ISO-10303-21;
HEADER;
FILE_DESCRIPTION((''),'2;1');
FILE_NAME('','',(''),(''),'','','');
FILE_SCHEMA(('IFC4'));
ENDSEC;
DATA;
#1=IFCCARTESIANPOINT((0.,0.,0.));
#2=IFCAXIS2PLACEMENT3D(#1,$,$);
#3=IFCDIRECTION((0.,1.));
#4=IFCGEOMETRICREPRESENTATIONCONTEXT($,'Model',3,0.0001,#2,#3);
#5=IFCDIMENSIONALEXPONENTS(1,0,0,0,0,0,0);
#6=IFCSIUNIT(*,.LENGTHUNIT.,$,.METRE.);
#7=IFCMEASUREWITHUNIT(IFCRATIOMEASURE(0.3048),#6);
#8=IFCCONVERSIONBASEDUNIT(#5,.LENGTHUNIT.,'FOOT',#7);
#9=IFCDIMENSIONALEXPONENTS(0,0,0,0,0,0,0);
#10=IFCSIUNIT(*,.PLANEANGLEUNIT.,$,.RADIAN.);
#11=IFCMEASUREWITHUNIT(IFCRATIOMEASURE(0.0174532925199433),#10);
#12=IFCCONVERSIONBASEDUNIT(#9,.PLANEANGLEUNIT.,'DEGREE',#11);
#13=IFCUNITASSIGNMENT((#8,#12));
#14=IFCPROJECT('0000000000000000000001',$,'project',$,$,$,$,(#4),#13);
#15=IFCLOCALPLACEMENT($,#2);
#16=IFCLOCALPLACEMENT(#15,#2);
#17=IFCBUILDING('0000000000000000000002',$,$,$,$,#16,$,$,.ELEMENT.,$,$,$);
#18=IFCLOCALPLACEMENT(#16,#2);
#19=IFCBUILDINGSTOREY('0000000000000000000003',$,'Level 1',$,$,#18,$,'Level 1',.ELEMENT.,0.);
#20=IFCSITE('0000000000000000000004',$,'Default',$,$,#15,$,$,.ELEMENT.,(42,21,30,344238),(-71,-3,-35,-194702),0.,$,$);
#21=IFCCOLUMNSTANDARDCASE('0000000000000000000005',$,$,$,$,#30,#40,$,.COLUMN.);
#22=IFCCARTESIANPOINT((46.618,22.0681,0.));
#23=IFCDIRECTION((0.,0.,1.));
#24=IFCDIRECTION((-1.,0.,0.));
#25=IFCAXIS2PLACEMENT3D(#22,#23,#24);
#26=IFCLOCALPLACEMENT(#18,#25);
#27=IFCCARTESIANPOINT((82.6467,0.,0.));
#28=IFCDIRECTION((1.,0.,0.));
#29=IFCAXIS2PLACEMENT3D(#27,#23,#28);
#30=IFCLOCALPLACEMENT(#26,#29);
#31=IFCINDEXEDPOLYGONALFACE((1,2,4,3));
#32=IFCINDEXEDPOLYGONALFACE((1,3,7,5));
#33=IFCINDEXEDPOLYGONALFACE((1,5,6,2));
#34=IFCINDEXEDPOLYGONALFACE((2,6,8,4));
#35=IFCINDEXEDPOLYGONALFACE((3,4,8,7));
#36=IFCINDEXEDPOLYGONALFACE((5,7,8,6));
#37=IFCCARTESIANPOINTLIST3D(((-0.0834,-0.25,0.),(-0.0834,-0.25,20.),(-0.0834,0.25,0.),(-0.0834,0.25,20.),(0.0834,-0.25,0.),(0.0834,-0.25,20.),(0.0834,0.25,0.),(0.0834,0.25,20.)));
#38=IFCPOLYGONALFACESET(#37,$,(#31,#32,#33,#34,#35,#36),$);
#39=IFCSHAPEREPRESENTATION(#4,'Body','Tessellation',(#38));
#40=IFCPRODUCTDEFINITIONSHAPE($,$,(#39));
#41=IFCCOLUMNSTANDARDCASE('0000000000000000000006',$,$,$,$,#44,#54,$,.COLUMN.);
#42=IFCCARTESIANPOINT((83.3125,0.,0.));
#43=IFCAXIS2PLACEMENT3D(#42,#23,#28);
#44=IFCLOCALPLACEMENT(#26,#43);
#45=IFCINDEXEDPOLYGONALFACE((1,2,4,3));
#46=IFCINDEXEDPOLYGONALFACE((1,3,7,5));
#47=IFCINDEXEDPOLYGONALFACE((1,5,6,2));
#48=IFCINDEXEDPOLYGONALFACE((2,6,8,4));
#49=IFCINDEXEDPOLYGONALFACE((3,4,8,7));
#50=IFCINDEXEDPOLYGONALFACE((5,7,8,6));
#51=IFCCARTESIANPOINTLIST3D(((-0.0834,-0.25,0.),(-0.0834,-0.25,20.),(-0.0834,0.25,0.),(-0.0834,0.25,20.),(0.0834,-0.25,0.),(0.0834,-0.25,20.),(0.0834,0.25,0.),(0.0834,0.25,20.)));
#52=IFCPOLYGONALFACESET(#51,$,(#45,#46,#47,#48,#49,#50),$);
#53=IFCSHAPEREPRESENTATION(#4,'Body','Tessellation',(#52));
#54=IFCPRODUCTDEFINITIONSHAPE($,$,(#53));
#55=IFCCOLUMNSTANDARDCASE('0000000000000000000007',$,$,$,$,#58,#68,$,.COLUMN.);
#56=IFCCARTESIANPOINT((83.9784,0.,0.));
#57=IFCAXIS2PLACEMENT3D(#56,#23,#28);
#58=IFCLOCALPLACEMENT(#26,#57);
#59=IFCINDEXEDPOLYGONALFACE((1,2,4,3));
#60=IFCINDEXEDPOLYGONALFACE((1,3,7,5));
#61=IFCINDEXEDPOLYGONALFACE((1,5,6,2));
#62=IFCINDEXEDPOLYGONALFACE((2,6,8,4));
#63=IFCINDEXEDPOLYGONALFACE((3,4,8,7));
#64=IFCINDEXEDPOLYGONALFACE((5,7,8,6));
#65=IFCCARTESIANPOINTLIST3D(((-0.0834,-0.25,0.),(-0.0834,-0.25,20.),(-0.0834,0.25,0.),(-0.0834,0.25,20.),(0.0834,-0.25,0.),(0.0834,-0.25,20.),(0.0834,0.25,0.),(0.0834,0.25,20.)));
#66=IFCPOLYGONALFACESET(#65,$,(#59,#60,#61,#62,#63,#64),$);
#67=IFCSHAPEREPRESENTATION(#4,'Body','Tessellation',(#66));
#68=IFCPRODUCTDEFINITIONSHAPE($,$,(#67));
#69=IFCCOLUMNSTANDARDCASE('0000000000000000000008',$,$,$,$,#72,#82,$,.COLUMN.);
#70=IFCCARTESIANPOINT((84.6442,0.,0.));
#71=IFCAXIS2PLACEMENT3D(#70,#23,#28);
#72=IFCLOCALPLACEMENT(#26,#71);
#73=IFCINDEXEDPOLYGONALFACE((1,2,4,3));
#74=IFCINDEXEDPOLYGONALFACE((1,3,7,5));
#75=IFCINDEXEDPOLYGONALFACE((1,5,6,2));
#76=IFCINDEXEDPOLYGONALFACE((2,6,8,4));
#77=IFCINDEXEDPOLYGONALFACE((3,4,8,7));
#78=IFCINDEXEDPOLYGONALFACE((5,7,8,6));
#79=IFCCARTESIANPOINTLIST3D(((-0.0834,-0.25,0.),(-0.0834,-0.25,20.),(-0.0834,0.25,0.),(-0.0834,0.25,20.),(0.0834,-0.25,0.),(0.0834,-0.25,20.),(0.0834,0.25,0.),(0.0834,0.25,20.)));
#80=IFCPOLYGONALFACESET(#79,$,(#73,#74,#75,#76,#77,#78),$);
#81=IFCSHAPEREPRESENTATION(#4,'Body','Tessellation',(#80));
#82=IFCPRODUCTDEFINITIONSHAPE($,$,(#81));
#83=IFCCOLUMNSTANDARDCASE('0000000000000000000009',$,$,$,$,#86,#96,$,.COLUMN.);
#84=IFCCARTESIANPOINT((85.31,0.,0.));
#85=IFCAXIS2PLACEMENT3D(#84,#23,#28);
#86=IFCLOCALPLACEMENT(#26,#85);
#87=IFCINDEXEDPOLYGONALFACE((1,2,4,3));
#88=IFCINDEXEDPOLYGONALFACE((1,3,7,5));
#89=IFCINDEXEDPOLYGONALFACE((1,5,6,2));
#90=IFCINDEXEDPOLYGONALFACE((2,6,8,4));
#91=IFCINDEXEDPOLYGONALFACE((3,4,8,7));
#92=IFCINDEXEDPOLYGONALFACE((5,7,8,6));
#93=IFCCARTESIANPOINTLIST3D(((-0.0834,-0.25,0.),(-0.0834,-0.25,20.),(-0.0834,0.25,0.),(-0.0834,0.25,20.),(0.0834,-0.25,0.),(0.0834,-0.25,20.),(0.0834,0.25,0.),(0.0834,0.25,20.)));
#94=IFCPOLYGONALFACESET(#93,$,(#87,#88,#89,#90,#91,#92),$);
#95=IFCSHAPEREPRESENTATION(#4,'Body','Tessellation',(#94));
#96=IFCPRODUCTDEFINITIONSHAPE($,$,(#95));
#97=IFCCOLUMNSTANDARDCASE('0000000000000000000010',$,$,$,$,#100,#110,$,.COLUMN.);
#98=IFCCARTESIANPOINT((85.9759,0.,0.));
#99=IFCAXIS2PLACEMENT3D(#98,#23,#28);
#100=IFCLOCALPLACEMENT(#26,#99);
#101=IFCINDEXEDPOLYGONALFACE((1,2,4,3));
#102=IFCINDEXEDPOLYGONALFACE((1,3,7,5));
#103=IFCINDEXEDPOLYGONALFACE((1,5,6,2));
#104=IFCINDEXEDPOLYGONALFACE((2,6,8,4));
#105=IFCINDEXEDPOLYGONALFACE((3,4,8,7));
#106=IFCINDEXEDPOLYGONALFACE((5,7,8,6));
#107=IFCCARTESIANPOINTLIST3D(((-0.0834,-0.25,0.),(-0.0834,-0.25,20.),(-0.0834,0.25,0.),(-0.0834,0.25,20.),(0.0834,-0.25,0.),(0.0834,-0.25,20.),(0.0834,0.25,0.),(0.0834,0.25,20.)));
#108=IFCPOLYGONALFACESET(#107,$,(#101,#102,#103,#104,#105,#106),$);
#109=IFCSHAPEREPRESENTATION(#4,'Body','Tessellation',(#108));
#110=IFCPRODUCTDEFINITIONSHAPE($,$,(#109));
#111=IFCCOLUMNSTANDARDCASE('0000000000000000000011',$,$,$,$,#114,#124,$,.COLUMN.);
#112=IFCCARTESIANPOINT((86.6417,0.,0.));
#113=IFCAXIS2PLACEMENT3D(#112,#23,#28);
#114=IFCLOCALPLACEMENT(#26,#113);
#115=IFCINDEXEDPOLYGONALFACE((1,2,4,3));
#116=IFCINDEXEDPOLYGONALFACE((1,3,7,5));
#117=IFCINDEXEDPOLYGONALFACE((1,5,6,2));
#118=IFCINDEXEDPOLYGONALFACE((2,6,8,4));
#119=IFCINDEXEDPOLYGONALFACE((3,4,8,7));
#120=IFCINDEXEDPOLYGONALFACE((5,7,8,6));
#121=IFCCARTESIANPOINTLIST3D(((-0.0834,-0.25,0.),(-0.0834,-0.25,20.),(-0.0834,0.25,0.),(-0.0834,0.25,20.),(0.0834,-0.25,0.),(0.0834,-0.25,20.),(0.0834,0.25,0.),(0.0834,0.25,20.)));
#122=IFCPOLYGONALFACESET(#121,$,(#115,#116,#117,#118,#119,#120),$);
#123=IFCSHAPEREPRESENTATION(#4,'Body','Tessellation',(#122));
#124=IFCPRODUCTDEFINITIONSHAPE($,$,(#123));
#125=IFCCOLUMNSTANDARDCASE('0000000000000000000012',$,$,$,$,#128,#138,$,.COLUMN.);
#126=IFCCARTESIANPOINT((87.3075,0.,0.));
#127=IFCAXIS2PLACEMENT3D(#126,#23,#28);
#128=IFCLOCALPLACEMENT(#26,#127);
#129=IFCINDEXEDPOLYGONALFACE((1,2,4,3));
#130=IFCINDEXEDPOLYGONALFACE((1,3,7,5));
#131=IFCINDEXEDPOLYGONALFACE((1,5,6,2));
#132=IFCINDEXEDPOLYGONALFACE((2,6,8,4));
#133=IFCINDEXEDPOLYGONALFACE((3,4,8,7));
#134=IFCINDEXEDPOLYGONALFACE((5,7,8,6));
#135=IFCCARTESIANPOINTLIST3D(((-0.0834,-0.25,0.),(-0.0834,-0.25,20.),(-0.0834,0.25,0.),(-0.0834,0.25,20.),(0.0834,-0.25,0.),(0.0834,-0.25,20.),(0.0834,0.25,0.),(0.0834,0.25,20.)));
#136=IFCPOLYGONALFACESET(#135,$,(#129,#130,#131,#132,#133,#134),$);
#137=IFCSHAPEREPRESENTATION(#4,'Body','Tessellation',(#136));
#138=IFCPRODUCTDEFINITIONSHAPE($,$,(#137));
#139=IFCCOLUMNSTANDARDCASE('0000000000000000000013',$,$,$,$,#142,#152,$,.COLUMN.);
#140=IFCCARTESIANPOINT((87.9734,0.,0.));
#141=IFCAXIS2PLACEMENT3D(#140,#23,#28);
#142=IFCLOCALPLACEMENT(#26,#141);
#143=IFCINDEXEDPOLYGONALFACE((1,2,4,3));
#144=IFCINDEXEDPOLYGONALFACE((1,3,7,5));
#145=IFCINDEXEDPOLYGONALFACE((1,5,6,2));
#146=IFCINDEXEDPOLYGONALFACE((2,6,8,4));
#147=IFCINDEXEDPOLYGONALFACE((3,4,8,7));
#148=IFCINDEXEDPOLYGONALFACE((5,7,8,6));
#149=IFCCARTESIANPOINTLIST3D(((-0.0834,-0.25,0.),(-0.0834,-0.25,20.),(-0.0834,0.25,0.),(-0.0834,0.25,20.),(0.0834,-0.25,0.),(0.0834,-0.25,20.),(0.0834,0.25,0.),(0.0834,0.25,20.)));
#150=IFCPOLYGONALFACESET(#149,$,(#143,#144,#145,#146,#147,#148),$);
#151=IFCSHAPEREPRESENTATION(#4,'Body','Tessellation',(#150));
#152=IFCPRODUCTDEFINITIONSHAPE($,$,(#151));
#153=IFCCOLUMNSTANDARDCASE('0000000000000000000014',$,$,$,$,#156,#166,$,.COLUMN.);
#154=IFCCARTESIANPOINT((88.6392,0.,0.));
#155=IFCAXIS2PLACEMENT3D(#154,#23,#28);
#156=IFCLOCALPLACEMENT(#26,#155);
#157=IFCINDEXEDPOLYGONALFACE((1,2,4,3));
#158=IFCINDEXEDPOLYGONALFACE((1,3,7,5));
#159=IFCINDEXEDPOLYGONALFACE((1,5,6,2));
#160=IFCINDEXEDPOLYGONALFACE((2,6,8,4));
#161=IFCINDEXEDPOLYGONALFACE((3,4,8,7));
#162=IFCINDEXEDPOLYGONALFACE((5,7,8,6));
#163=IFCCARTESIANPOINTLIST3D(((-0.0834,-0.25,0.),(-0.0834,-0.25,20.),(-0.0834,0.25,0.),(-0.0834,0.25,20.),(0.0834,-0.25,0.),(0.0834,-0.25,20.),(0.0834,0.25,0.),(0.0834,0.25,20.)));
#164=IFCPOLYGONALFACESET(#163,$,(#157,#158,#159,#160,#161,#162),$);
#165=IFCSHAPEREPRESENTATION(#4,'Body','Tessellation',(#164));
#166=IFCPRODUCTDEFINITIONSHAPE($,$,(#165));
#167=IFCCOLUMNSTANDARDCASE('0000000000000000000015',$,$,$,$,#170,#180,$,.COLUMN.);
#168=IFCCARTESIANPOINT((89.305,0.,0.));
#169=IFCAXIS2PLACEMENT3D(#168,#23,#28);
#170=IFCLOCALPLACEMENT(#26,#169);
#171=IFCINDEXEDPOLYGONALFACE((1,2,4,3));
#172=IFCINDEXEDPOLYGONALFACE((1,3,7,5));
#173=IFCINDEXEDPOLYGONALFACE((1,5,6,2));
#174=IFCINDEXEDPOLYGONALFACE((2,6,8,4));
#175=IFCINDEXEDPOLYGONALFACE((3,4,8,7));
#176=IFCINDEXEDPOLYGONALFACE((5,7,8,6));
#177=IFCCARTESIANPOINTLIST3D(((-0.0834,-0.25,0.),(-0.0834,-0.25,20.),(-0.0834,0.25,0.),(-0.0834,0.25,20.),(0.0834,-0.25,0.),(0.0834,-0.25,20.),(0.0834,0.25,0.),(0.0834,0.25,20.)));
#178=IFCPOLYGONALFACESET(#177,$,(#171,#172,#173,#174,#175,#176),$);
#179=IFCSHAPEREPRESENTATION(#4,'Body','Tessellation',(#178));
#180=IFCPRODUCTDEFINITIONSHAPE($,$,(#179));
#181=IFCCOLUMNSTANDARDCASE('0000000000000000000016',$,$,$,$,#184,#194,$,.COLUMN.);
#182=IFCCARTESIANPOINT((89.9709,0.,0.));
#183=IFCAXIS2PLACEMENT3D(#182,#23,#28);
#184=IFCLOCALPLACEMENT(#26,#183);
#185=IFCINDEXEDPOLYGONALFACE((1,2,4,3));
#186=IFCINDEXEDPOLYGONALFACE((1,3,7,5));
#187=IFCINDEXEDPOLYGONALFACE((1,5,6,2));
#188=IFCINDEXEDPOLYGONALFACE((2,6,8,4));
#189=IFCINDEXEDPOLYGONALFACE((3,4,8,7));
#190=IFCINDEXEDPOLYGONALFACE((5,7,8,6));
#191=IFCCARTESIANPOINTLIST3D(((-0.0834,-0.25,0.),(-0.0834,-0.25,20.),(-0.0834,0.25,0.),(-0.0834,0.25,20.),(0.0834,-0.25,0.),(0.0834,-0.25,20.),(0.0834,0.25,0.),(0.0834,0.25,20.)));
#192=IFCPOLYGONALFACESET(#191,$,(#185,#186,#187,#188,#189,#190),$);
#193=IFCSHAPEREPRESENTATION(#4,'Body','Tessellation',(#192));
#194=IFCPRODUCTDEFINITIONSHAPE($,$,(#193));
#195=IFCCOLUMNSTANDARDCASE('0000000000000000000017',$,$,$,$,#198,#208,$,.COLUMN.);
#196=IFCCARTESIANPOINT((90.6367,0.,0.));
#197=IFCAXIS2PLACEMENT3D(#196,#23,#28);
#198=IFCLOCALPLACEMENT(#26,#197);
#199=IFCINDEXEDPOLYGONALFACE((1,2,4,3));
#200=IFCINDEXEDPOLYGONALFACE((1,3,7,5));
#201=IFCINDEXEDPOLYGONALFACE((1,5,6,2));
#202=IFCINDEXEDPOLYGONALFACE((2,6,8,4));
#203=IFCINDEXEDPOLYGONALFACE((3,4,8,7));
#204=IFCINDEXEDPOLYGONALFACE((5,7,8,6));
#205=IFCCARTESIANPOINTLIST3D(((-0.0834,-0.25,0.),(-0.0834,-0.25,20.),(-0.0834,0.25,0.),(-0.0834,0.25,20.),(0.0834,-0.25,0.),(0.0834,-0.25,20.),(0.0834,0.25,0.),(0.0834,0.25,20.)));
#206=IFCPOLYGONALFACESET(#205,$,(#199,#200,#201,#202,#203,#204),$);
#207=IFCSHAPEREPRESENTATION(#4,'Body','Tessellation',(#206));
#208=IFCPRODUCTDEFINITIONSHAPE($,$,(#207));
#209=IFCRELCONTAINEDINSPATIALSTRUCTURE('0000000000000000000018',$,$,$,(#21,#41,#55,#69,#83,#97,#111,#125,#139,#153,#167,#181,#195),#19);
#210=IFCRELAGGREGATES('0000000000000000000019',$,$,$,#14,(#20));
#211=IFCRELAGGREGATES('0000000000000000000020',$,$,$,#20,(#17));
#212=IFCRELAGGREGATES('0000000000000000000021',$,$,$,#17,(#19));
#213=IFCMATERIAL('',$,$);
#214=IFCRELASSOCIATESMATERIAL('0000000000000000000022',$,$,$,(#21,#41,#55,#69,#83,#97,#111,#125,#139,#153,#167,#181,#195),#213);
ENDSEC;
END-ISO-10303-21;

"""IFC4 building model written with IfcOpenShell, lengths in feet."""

from ifc_helpers import new_model, entity, si_unit, converted_unit, direction, frame, origin, place, context, project, spatial, rectangle, extrude, material, element, save


model = new_model("IFC4")

# Units and contexts
model_context = context("Model", 3, precision=0.0001, world=origin(), true_north=direction((0.0, 1.0)))
ifc_project = project(units=[converted_unit("LENGTHUNIT", "FOOT", entity("IfcRatioMeasure", 0.3048), si_unit("LENGTHUNIT", "METRE"), dimensions=[1, 0, 0, 0, 0, 0, 0]), converted_unit("PLANEANGLEUNIT", "DEGREE", entity("IfcRatioMeasure", 0.0174532925199433), si_unit("PLANEANGLEUNIT", "RADIAN"), dimensions=[0, 0, 0, 0, 0, 0, 0])], contexts=[model_context])

# Site, building, storey
site_placement = place(None, origin())
site = spatial("IfcSite", under=ifc_project, at=site_placement, Name="Default", CompositionType="ELEMENT", RefLatitude=(42, 21, 30, 344238), RefLongitude=(-71, -3, -35, -194702), RefElevation=0.0)
building_placement = place(site_placement, origin())
building = spatial("IfcBuilding", under=site, at=building_placement, CompositionType="ELEMENT")
storey_placement = place(building_placement, origin())
storey = spatial("IfcBuildingStorey", under=building, at=storey_placement, Name="Level 1", LongName="Level 1", CompositionType="ELEMENT", Elevation=0.0)

# Columns
ifc_material = material(Name="")
placement = place(storey_placement, frame((46.618, 22.0681, 0.0), z_axis=(0.0, 0.0, 1.0), x_axis=(-1.0, 0.0, 0.0)))
for number, where, z_axis, x_axis in (
    (1, (82.6467, 0.0, 0.0), (0.0, 0.0, 1.0), (1.0, 0.0, 0.0)),
    (2, (83.3125, 0.0, 0.0), (0.0, 0.0, 1.0), (1.0, 0.0, 0.0)),
    (3, (83.9784, 0.0, 0.0), (0.0, 0.0, 1.0), (1.0, 0.0, 0.0)),
    (4, (84.6442, 0.0, 0.0), (0.0, 0.0, 1.0), (1.0, 0.0, 0.0)),
    (5, (85.31, 0.0, 0.0), (0.0, 0.0, 1.0), (1.0, 0.0, 0.0)),
    (6, (85.9759, 0.0, 0.0), (0.0, 0.0, 1.0), (1.0, 0.0, 0.0)),
    (7, (86.6417, 0.0, 0.0), (0.0, 0.0, 1.0), (1.0, 0.0, 0.0)),
    (8, (87.3075, 0.0, 0.0), (0.0, 0.0, 1.0), (1.0, 0.0, 0.0)),
    (9, (87.9734, 0.0, 0.0), (0.0, 0.0, 1.0), (1.0, 0.0, 0.0)),
    (10, (88.6392, 0.0, 0.0), (0.0, 0.0, 1.0), (1.0, 0.0, 0.0)),
    (11, (89.305, 0.0, 0.0), (0.0, 0.0, 1.0), (1.0, 0.0, 0.0)),
    (12, (89.9709, 0.0, 0.0), (0.0, 0.0, 1.0), (1.0, 0.0, 0.0)),
    (13, (90.6367, 0.0, 0.0), (0.0, 0.0, 1.0), (1.0, 0.0, 0.0)),
):
    element("IfcColumnStandardCase", number, at=place(placement, frame(where, z_axis=z_axis, x_axis=x_axis)), inside=storey, material=ifc_material, PredefinedType="COLUMN", context=model_context, shape_type="SweptSolid", body=[
        extrude(rectangle(XDim=0.1667, YDim=0.5), origin(), (0.0, 0.0, 1.0), 20.0),
    ])

save(model, "model.ifc")
